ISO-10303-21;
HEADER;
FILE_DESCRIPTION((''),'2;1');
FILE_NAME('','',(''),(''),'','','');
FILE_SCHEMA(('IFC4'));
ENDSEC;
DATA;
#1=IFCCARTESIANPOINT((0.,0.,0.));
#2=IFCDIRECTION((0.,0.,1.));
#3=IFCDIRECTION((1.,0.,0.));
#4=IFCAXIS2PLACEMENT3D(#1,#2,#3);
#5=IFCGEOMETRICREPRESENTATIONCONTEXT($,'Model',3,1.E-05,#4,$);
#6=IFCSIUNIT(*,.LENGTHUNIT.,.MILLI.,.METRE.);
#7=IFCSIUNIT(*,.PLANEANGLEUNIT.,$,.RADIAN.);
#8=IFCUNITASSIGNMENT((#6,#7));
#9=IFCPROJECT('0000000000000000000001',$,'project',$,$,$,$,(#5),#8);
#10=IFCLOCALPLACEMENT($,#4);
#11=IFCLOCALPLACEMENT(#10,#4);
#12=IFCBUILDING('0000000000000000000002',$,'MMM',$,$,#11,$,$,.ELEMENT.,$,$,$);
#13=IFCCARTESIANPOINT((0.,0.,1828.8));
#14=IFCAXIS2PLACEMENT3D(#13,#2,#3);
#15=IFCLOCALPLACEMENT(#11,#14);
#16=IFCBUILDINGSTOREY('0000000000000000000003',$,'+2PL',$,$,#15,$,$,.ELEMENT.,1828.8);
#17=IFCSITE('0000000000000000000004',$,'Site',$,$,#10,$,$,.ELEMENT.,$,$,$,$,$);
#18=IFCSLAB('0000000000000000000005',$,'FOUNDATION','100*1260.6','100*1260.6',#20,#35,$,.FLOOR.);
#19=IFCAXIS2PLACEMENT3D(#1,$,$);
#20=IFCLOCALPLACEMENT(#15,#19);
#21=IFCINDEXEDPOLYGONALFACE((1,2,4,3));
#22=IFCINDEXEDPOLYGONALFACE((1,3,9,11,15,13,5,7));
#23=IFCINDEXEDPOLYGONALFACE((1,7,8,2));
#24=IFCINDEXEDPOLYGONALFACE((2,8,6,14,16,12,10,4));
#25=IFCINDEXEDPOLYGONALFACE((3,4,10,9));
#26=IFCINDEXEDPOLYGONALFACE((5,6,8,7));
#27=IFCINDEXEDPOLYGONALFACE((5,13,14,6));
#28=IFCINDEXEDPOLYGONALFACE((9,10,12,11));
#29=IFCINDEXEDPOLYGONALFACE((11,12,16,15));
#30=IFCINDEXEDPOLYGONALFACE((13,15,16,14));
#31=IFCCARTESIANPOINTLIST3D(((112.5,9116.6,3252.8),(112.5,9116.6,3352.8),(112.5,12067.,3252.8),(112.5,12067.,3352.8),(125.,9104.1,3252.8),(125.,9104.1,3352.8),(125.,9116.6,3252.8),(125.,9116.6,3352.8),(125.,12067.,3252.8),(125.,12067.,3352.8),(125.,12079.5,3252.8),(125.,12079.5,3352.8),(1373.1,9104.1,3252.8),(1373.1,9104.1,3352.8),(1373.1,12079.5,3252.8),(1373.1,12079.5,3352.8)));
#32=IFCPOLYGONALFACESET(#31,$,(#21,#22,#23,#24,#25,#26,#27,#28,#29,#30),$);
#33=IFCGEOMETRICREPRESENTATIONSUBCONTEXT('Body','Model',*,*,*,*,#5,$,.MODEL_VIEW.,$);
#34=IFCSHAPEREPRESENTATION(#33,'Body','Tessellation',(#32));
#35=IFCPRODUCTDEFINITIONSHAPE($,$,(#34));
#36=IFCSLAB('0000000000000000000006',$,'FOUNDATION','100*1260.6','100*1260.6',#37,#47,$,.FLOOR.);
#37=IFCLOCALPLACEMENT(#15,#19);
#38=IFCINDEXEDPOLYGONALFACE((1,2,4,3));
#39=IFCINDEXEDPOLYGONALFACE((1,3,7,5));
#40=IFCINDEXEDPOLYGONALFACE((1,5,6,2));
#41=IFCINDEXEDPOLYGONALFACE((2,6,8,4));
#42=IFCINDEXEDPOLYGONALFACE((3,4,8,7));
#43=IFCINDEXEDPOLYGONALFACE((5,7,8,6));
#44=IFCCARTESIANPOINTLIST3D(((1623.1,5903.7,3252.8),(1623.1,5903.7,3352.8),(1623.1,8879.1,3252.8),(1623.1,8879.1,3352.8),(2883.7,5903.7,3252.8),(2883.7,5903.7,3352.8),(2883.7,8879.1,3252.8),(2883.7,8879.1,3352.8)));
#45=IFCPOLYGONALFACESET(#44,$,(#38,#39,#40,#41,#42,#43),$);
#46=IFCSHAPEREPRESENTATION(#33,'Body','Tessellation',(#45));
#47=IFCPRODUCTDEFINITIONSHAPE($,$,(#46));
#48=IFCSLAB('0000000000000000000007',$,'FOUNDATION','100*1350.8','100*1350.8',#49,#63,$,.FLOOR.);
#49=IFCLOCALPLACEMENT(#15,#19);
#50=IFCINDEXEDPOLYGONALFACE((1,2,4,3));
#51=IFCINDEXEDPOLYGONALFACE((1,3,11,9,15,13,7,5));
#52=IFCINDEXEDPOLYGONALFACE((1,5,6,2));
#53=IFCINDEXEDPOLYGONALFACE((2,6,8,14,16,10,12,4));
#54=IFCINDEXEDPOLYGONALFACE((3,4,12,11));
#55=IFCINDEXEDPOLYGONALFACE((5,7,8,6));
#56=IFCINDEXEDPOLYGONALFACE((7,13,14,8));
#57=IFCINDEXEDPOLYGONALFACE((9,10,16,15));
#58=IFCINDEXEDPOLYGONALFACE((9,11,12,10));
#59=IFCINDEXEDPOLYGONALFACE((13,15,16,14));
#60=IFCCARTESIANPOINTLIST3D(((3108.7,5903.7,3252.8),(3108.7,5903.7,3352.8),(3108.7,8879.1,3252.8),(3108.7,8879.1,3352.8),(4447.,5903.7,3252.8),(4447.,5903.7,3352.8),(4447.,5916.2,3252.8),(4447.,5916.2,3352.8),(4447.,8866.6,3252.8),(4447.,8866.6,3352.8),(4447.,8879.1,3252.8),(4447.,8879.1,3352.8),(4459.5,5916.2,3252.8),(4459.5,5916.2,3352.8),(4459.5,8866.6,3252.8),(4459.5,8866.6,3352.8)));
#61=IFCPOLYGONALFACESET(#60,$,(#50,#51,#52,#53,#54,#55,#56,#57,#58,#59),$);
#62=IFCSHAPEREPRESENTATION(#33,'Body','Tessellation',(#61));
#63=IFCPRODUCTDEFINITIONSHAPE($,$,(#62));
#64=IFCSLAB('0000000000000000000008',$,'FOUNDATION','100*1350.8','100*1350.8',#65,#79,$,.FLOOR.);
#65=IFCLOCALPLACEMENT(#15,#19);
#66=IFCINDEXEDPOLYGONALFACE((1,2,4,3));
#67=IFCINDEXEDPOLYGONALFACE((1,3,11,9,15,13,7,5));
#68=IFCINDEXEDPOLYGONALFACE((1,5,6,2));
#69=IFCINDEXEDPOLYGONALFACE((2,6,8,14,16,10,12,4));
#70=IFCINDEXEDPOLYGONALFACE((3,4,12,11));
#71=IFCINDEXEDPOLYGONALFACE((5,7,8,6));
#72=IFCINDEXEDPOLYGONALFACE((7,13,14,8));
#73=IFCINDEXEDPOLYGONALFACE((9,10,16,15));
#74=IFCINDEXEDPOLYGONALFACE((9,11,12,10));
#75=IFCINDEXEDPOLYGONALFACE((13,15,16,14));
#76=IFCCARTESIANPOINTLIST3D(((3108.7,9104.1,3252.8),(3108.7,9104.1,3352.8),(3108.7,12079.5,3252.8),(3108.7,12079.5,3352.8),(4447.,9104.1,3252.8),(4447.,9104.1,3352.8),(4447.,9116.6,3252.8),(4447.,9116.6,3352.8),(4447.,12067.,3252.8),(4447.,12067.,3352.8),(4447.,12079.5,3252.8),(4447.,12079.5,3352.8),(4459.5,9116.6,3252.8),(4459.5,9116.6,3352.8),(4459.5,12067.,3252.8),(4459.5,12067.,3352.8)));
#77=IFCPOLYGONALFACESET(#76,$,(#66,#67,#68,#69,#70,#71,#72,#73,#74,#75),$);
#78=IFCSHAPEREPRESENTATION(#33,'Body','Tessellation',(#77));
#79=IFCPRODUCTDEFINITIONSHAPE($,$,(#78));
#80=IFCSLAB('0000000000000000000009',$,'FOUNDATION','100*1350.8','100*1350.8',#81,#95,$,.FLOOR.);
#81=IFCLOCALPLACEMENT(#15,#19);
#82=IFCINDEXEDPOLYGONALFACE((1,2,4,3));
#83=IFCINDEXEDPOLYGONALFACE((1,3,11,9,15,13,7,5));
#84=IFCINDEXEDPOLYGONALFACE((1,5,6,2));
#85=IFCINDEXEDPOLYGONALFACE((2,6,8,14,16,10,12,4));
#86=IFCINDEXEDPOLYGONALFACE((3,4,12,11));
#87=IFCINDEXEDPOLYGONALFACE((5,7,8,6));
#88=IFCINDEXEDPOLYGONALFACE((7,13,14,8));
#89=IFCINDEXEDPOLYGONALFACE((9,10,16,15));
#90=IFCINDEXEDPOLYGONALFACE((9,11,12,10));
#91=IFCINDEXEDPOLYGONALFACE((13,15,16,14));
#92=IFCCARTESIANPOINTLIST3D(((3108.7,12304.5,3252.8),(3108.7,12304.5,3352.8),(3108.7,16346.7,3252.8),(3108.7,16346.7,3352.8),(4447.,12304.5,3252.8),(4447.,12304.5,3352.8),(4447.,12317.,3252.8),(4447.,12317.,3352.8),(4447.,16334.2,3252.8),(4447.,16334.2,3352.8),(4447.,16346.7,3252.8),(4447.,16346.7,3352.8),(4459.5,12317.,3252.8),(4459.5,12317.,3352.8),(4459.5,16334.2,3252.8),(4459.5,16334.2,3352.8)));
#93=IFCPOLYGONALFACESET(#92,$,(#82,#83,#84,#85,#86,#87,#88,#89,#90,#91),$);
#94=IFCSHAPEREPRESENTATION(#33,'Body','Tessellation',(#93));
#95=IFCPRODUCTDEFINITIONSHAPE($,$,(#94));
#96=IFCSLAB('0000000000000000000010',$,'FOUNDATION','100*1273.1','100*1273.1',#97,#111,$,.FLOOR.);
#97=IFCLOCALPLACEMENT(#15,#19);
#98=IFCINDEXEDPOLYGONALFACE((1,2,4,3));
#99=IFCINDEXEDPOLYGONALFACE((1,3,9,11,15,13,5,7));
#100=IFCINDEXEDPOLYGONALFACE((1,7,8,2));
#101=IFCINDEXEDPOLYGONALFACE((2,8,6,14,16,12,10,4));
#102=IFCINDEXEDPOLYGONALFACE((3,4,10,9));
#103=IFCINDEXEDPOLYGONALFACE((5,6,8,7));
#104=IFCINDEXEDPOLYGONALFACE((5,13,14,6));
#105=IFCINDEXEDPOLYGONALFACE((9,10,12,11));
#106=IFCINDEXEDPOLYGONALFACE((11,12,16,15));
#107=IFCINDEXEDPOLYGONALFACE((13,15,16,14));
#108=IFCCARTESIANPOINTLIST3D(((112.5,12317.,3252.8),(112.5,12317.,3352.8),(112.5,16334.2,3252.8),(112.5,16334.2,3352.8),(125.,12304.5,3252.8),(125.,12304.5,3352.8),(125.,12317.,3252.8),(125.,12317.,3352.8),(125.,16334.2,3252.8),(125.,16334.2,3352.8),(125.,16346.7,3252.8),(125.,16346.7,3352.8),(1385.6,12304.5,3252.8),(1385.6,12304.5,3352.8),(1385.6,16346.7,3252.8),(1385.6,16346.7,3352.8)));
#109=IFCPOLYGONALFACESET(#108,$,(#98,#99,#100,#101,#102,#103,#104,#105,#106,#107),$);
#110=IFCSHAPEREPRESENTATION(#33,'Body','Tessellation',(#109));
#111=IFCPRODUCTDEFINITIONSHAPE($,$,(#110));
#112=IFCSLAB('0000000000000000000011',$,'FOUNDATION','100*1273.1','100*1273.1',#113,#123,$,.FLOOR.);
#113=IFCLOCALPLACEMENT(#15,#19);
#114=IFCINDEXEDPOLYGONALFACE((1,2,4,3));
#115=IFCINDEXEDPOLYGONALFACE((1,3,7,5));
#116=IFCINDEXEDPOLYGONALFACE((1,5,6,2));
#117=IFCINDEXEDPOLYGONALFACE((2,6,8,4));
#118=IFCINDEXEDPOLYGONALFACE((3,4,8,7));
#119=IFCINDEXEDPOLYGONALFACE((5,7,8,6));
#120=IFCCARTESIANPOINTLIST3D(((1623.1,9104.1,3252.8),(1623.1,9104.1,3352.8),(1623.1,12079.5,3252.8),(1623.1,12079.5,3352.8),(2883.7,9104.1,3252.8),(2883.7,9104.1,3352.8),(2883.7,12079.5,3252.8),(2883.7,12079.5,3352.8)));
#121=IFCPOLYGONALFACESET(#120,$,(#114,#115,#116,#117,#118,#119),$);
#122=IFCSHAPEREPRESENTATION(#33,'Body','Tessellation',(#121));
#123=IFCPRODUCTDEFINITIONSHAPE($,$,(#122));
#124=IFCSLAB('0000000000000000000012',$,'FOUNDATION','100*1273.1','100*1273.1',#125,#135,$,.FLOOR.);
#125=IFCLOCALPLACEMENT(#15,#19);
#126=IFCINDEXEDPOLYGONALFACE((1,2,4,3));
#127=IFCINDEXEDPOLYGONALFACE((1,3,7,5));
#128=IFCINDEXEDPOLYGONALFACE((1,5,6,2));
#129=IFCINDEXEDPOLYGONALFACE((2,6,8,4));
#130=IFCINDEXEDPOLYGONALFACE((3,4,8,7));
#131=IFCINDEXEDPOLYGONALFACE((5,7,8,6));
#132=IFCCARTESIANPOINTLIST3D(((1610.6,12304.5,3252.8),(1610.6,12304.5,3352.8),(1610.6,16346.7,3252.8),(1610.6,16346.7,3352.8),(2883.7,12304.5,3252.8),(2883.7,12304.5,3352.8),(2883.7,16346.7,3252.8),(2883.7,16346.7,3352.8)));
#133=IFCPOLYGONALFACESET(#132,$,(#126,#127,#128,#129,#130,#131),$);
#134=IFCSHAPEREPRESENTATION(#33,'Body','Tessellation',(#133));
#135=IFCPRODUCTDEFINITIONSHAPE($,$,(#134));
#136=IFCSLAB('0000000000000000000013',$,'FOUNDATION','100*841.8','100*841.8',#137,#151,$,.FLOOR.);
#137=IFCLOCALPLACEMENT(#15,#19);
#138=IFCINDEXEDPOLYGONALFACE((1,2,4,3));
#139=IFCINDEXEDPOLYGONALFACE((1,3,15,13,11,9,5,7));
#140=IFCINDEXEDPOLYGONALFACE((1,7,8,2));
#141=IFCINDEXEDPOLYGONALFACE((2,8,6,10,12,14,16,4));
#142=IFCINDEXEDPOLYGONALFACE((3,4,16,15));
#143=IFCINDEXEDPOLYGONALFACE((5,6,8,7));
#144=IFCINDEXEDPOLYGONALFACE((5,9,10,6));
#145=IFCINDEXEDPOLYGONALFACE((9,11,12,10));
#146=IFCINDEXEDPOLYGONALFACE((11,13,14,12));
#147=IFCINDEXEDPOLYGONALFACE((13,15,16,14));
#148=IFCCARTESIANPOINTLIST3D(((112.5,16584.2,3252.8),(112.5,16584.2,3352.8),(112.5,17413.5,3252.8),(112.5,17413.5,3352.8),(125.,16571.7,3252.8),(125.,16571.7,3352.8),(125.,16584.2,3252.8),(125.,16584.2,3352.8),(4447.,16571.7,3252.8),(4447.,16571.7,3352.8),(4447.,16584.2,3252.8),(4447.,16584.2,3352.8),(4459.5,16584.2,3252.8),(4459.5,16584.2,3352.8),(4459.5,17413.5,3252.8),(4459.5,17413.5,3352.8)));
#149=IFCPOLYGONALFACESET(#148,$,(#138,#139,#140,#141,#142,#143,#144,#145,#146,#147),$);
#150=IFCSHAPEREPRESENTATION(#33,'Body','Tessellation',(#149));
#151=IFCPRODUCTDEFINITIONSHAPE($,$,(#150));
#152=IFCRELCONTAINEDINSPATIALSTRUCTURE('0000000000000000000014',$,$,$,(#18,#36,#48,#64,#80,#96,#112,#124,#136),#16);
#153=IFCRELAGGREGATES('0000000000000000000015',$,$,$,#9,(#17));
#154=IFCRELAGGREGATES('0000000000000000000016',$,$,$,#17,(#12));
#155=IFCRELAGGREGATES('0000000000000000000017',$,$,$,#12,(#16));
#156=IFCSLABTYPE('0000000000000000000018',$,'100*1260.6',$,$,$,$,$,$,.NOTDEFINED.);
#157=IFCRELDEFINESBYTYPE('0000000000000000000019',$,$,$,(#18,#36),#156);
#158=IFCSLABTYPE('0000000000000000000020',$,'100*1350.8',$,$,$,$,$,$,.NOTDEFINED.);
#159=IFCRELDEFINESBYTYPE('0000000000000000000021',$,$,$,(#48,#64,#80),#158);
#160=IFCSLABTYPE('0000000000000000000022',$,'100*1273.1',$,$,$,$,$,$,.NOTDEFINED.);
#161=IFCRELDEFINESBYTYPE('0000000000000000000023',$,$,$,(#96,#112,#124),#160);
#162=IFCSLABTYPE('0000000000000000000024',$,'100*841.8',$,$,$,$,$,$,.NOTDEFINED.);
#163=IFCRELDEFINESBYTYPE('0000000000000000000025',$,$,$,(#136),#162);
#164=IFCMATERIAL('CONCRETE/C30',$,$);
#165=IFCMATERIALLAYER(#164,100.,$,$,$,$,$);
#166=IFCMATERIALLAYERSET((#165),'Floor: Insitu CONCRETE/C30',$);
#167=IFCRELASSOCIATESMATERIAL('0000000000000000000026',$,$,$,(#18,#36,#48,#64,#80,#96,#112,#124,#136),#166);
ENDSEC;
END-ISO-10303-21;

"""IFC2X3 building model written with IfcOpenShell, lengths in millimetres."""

from ifc_helpers import new_model, si_unit, frame, origin_with_axes, place, context, subcontext, project, spatial, polyline, outline, extrude, material, layer, layer_set, layer_usage, type_object, element, save


model = new_model("IFC2X3")

# Units and contexts
model_context = context("Model", 3, precision=1e-05, world=origin_with_axes())
body_context = subcontext(model_context, "Body", "Model", "MODEL_VIEW")
ifc_project = project(units=[si_unit("LENGTHUNIT", "METRE", prefix="MILLI"), si_unit("PLANEANGLEUNIT", "RADIAN")], contexts=[model_context])

# Site, building, storey
site_placement = place(None, origin_with_axes())
site = spatial("IfcSite", under=ifc_project, at=site_placement, Name="Site", CompositionType="ELEMENT")
building_placement = place(site_placement, origin_with_axes())
building = spatial("IfcBuilding", under=site, at=building_placement, Name="MMM", CompositionType="ELEMENT")
storey_placement = place(building_placement, frame((0.0, 0.0, 1828.8), z_axis=(0.0, 0.0, 1.0), x_axis=(1.0, 0.0, 0.0)))
storey = spatial("IfcBuildingStorey", under=building, at=storey_placement, Name="+2PL", CompositionType="ELEMENT", Elevation=1828.8)

# Shared definitions
ifc_material = material(Name="CONCRETE/C30")

# Slabs
ifc_layer = layer(ifc_material, 100.0)
ifc_layer_set = layer_set([ifc_layer], Name="Floor: Insitu CONCRETE/C30")
slab_type_1 = type_object("IfcSlabType", Name="100*1260.6", PredefinedType="NOTDEFINED")
ifc_layer_usage_1 = layer_usage(ifc_layer_set, "AXIS3", "POSITIVE", -50.0)
slab_1_placement = place(storey_placement, frame((112.5, 9116.6, 3302.8), z_axis=(0.0, 0.0, 1.0), x_axis=(1.0, 0.0, 0.0)))
element("IfcSlab", 1, at=slab_1_placement, inside=storey, type_object=slab_type_1, material=ifc_layer_usage_1, Name="FOUNDATION", Description="100*1260.6", ObjectType="100*1260.6", PredefinedType="FLOOR", context=body_context, shape_type="SweptSolid", body=[
    extrude(outline(polyline([(0.0, 0.0), (12.5, 0.0), (12.5, -12.5), (1260.6, -12.5), (1260.6, 2962.9), (12.5, 2962.9), (12.5, 2950.4), (0.0, 2950.4), (0.0, 0.0)])), frame((0.0, 0.0, -50.0), z_axis=(0.0, 0.0, 1.0), x_axis=(1.0, 0.0, 0.0)), (0.0, 0.0, 1.0), 100.0),
])
ifc_layer_usage_2 = layer_usage(ifc_layer_set, "AXIS3", "POSITIVE", -50.0)
slab_2_placement = place(storey_placement, frame((2883.7, 8879.1, 3302.8), z_axis=(0.0, 0.0, 1.0), x_axis=(-1.0, 0.0, 0.0)))
element("IfcSlab", 2, at=slab_2_placement, inside=storey, type_object=slab_type_1, material=ifc_layer_usage_2, Name="FOUNDATION", Description="100*1260.6", ObjectType="100*1260.6", PredefinedType="FLOOR", context=body_context, shape_type="SweptSolid", body=[
    extrude(outline(polyline([(0.0, 0.0), (1260.6, 0.0), (1260.6, 2975.4), (0.0, 2975.4), (0.0, 0.0)])), frame((0.0, 0.0, -50.0), z_axis=(0.0, 0.0, 1.0), x_axis=(1.0, 0.0, 0.0)), (0.0, 0.0, 1.0), 100.0),
])
ifc_layer_usage_3 = layer_usage(ifc_layer_set, "AXIS3", "POSITIVE", -50.0)
slab_type_2 = type_object("IfcSlabType", Name="100*1350.8", PredefinedType="NOTDEFINED")
slab_3_placement = place(storey_placement, frame((4447.0, 8866.6, 3302.8), z_axis=(0.0, 0.0, -1.0), x_axis=(1.0, 0.0, 0.0)))
element("IfcSlab", 3, at=slab_3_placement, inside=storey, type_object=slab_type_2, material=ifc_layer_usage_3, Name="FOUNDATION", Description="100*1350.8", ObjectType="100*1350.8", PredefinedType="FLOOR", context=body_context, shape_type="SweptSolid", body=[
    extrude(outline(polyline([(0.0, 0.0), (12.5, 0.0), (12.5, 2950.4), (0.0, 2950.4), (0.0, 2962.9), (-1338.3, 2962.9), (-1338.3, -12.5), (0.0, -12.5), (0.0, 0.0)])), frame((0.0, 0.0, -50.0), z_axis=(0.0, 0.0, 1.0), x_axis=(1.0, 0.0, 0.0)), (0.0, 0.0, 1.0), 100.0),
])
ifc_layer_usage_4 = layer_usage(ifc_layer_set, "AXIS3", "POSITIVE", -50.0)
slab_4_placement = place(storey_placement, frame((4459.5, 9116.6, 3302.8), z_axis=(0.0, 0.0, -1.0), x_axis=(-1.0, 0.0, 0.0)))
element("IfcSlab", 4, at=slab_4_placement, inside=storey, type_object=slab_type_2, material=ifc_layer_usage_4, Name="FOUNDATION", Description="100*1350.8", ObjectType="100*1350.8", PredefinedType="FLOOR", context=body_context, shape_type="SweptSolid", body=[
    extrude(outline(polyline([(0.0, 0.0), (12.5, 0.0), (12.5, -12.5), (1350.8, -12.5), (1350.8, 2962.9), (12.5, 2962.9), (12.5, 2950.4), (0.0, 2950.4), (0.0, 0.0)])), frame((0.0, 0.0, -50.0), z_axis=(0.0, 0.0, 1.0), x_axis=(1.0, 0.0, 0.0)), (0.0, 0.0, 1.0), 100.0),
])
ifc_layer_usage_5 = layer_usage(ifc_layer_set, "AXIS3", "POSITIVE", -50.0)
slab_5_placement = place(storey_placement, frame((4447.0, 12317.0, 3302.8), z_axis=(0.0, 0.0, -1.0), x_axis=(0.0, -1.0, 0.0)))
element("IfcSlab", 5, at=slab_5_placement, inside=storey, type_object=slab_type_2, material=ifc_layer_usage_5, Name="FOUNDATION", Description="100*1350.8", ObjectType="100*1350.8", PredefinedType="FLOOR", context=body_context, shape_type="SweptSolid", body=[
    extrude(outline(polyline([(0.0, 0.0), (12.5, 0.0), (12.5, 1338.3), (-4029.7, 1338.3), (-4029.7, 0.0), (-4017.2, 0.0), (-4017.2, -12.5), (0.0, -12.5), (0.0, 0.0)])), frame((0.0, 0.0, -50.0), z_axis=(0.0, 0.0, 1.0), x_axis=(1.0, 0.0, 0.0)), (0.0, 0.0, 1.0), 100.0),
])
ifc_layer_usage_6 = layer_usage(ifc_layer_set, "AXIS3", "POSITIVE", -50.0)
slab_type_3 = type_object("IfcSlabType", Name="100*1273.1", PredefinedType="NOTDEFINED")
slab_6_placement = place(storey_placement, frame((125.0, 12317.0, 3302.8), z_axis=(0.0, 0.0, 1.0), x_axis=(0.0, -1.0, 0.0)))
element("IfcSlab", 6, at=slab_6_placement, inside=storey, type_object=slab_type_3, material=ifc_layer_usage_6, Name="FOUNDATION", Description="100*1273.1", ObjectType="100*1273.1", PredefinedType="FLOOR", context=body_context, shape_type="SweptSolid", body=[
    extrude(outline(polyline([(0.0, 0.0), (12.5, 0.0), (12.5, 1260.6), (-4029.7, 1260.6), (-4029.7, 0.0), (-4017.2, 0.0), (-4017.2, -12.5), (0.0, -12.5), (0.0, 0.0)])), frame((0.0, 0.0, -50.0), z_axis=(0.0, 0.0, 1.0), x_axis=(1.0, 0.0, 0.0)), (0.0, 0.0, 1.0), 100.0),
])
ifc_layer_usage_7 = layer_usage(ifc_layer_set, "AXIS3", "POSITIVE", -50.0)
slab_7_placement = place(storey_placement, frame((2883.7, 12079.5, 3302.8), z_axis=(0.0, 0.0, 1.0), x_axis=(-1.0, 0.0, 0.0)))
element("IfcSlab", 7, at=slab_7_placement, inside=storey, type_object=slab_type_3, material=ifc_layer_usage_7, Name="FOUNDATION", Description="100*1273.1", ObjectType="100*1273.1", PredefinedType="FLOOR", context=body_context, shape_type="SweptSolid", body=[
    extrude(outline(polyline([(0.0, 0.0), (1260.6, 0.0), (1260.6, 2975.4), (0.0, 2975.4), (0.0, 0.0)])), frame((0.0, 0.0, -50.0), z_axis=(0.0, 0.0, 1.0), x_axis=(1.0, 0.0, 0.0)), (0.0, 0.0, 1.0), 100.0),
])
ifc_layer_usage_8 = layer_usage(ifc_layer_set, "AXIS3", "POSITIVE", -50.0)
slab_8_placement = place(storey_placement, frame((2883.7, 16346.7, 3302.8), z_axis=(0.0, 0.0, 1.0), x_axis=(-1.0, 0.0, 0.0)))
element("IfcSlab", 8, at=slab_8_placement, inside=storey, type_object=slab_type_3, material=ifc_layer_usage_8, Name="FOUNDATION", Description="100*1273.1", ObjectType="100*1273.1", PredefinedType="FLOOR", context=body_context, shape_type="SweptSolid", body=[
    extrude(outline(polyline([(0.0, 0.0), (1273.1, 0.0), (1273.1, 4042.2), (0.0, 4042.2), (0.0, 0.0)])), frame((0.0, 0.0, -50.0), z_axis=(0.0, 0.0, 1.0), x_axis=(1.0, 0.0, 0.0)), (0.0, 0.0, 1.0), 100.0),
])
ifc_layer_usage_9 = layer_usage(ifc_layer_set, "AXIS3", "POSITIVE", -50.0)
slab_type_4 = type_object("IfcSlabType", Name="100*841.8", PredefinedType="NOTDEFINED")
slab_9_placement = place(storey_placement, frame((112.5, 17413.5, 3302.8), z_axis=(0.0, 0.0, 1.0), x_axis=(0.0, -1.0, 0.0)))
element("IfcSlab", 9, at=slab_9_placement, inside=storey, type_object=slab_type_4, material=ifc_layer_usage_9, Name="FOUNDATION", Description="100*841.8", ObjectType="100*841.8", PredefinedType="FLOOR", context=body_context, shape_type="SweptSolid", body=[
    extrude(outline(polyline([(0.0, 0.0), (829.3, 0.0), (829.3, 12.5), (841.8, 12.5), (841.8, 4334.5), (829.3, 4334.5), (829.3, 4347.0), (0.0, 4347.0), (0.0, 0.0)])), frame((0.0, 0.0, -50.0), z_axis=(0.0, 0.0, 1.0), x_axis=(1.0, 0.0, 0.0)), (0.0, 0.0, 1.0), 100.0),
])

save(model, "model.ifc")
